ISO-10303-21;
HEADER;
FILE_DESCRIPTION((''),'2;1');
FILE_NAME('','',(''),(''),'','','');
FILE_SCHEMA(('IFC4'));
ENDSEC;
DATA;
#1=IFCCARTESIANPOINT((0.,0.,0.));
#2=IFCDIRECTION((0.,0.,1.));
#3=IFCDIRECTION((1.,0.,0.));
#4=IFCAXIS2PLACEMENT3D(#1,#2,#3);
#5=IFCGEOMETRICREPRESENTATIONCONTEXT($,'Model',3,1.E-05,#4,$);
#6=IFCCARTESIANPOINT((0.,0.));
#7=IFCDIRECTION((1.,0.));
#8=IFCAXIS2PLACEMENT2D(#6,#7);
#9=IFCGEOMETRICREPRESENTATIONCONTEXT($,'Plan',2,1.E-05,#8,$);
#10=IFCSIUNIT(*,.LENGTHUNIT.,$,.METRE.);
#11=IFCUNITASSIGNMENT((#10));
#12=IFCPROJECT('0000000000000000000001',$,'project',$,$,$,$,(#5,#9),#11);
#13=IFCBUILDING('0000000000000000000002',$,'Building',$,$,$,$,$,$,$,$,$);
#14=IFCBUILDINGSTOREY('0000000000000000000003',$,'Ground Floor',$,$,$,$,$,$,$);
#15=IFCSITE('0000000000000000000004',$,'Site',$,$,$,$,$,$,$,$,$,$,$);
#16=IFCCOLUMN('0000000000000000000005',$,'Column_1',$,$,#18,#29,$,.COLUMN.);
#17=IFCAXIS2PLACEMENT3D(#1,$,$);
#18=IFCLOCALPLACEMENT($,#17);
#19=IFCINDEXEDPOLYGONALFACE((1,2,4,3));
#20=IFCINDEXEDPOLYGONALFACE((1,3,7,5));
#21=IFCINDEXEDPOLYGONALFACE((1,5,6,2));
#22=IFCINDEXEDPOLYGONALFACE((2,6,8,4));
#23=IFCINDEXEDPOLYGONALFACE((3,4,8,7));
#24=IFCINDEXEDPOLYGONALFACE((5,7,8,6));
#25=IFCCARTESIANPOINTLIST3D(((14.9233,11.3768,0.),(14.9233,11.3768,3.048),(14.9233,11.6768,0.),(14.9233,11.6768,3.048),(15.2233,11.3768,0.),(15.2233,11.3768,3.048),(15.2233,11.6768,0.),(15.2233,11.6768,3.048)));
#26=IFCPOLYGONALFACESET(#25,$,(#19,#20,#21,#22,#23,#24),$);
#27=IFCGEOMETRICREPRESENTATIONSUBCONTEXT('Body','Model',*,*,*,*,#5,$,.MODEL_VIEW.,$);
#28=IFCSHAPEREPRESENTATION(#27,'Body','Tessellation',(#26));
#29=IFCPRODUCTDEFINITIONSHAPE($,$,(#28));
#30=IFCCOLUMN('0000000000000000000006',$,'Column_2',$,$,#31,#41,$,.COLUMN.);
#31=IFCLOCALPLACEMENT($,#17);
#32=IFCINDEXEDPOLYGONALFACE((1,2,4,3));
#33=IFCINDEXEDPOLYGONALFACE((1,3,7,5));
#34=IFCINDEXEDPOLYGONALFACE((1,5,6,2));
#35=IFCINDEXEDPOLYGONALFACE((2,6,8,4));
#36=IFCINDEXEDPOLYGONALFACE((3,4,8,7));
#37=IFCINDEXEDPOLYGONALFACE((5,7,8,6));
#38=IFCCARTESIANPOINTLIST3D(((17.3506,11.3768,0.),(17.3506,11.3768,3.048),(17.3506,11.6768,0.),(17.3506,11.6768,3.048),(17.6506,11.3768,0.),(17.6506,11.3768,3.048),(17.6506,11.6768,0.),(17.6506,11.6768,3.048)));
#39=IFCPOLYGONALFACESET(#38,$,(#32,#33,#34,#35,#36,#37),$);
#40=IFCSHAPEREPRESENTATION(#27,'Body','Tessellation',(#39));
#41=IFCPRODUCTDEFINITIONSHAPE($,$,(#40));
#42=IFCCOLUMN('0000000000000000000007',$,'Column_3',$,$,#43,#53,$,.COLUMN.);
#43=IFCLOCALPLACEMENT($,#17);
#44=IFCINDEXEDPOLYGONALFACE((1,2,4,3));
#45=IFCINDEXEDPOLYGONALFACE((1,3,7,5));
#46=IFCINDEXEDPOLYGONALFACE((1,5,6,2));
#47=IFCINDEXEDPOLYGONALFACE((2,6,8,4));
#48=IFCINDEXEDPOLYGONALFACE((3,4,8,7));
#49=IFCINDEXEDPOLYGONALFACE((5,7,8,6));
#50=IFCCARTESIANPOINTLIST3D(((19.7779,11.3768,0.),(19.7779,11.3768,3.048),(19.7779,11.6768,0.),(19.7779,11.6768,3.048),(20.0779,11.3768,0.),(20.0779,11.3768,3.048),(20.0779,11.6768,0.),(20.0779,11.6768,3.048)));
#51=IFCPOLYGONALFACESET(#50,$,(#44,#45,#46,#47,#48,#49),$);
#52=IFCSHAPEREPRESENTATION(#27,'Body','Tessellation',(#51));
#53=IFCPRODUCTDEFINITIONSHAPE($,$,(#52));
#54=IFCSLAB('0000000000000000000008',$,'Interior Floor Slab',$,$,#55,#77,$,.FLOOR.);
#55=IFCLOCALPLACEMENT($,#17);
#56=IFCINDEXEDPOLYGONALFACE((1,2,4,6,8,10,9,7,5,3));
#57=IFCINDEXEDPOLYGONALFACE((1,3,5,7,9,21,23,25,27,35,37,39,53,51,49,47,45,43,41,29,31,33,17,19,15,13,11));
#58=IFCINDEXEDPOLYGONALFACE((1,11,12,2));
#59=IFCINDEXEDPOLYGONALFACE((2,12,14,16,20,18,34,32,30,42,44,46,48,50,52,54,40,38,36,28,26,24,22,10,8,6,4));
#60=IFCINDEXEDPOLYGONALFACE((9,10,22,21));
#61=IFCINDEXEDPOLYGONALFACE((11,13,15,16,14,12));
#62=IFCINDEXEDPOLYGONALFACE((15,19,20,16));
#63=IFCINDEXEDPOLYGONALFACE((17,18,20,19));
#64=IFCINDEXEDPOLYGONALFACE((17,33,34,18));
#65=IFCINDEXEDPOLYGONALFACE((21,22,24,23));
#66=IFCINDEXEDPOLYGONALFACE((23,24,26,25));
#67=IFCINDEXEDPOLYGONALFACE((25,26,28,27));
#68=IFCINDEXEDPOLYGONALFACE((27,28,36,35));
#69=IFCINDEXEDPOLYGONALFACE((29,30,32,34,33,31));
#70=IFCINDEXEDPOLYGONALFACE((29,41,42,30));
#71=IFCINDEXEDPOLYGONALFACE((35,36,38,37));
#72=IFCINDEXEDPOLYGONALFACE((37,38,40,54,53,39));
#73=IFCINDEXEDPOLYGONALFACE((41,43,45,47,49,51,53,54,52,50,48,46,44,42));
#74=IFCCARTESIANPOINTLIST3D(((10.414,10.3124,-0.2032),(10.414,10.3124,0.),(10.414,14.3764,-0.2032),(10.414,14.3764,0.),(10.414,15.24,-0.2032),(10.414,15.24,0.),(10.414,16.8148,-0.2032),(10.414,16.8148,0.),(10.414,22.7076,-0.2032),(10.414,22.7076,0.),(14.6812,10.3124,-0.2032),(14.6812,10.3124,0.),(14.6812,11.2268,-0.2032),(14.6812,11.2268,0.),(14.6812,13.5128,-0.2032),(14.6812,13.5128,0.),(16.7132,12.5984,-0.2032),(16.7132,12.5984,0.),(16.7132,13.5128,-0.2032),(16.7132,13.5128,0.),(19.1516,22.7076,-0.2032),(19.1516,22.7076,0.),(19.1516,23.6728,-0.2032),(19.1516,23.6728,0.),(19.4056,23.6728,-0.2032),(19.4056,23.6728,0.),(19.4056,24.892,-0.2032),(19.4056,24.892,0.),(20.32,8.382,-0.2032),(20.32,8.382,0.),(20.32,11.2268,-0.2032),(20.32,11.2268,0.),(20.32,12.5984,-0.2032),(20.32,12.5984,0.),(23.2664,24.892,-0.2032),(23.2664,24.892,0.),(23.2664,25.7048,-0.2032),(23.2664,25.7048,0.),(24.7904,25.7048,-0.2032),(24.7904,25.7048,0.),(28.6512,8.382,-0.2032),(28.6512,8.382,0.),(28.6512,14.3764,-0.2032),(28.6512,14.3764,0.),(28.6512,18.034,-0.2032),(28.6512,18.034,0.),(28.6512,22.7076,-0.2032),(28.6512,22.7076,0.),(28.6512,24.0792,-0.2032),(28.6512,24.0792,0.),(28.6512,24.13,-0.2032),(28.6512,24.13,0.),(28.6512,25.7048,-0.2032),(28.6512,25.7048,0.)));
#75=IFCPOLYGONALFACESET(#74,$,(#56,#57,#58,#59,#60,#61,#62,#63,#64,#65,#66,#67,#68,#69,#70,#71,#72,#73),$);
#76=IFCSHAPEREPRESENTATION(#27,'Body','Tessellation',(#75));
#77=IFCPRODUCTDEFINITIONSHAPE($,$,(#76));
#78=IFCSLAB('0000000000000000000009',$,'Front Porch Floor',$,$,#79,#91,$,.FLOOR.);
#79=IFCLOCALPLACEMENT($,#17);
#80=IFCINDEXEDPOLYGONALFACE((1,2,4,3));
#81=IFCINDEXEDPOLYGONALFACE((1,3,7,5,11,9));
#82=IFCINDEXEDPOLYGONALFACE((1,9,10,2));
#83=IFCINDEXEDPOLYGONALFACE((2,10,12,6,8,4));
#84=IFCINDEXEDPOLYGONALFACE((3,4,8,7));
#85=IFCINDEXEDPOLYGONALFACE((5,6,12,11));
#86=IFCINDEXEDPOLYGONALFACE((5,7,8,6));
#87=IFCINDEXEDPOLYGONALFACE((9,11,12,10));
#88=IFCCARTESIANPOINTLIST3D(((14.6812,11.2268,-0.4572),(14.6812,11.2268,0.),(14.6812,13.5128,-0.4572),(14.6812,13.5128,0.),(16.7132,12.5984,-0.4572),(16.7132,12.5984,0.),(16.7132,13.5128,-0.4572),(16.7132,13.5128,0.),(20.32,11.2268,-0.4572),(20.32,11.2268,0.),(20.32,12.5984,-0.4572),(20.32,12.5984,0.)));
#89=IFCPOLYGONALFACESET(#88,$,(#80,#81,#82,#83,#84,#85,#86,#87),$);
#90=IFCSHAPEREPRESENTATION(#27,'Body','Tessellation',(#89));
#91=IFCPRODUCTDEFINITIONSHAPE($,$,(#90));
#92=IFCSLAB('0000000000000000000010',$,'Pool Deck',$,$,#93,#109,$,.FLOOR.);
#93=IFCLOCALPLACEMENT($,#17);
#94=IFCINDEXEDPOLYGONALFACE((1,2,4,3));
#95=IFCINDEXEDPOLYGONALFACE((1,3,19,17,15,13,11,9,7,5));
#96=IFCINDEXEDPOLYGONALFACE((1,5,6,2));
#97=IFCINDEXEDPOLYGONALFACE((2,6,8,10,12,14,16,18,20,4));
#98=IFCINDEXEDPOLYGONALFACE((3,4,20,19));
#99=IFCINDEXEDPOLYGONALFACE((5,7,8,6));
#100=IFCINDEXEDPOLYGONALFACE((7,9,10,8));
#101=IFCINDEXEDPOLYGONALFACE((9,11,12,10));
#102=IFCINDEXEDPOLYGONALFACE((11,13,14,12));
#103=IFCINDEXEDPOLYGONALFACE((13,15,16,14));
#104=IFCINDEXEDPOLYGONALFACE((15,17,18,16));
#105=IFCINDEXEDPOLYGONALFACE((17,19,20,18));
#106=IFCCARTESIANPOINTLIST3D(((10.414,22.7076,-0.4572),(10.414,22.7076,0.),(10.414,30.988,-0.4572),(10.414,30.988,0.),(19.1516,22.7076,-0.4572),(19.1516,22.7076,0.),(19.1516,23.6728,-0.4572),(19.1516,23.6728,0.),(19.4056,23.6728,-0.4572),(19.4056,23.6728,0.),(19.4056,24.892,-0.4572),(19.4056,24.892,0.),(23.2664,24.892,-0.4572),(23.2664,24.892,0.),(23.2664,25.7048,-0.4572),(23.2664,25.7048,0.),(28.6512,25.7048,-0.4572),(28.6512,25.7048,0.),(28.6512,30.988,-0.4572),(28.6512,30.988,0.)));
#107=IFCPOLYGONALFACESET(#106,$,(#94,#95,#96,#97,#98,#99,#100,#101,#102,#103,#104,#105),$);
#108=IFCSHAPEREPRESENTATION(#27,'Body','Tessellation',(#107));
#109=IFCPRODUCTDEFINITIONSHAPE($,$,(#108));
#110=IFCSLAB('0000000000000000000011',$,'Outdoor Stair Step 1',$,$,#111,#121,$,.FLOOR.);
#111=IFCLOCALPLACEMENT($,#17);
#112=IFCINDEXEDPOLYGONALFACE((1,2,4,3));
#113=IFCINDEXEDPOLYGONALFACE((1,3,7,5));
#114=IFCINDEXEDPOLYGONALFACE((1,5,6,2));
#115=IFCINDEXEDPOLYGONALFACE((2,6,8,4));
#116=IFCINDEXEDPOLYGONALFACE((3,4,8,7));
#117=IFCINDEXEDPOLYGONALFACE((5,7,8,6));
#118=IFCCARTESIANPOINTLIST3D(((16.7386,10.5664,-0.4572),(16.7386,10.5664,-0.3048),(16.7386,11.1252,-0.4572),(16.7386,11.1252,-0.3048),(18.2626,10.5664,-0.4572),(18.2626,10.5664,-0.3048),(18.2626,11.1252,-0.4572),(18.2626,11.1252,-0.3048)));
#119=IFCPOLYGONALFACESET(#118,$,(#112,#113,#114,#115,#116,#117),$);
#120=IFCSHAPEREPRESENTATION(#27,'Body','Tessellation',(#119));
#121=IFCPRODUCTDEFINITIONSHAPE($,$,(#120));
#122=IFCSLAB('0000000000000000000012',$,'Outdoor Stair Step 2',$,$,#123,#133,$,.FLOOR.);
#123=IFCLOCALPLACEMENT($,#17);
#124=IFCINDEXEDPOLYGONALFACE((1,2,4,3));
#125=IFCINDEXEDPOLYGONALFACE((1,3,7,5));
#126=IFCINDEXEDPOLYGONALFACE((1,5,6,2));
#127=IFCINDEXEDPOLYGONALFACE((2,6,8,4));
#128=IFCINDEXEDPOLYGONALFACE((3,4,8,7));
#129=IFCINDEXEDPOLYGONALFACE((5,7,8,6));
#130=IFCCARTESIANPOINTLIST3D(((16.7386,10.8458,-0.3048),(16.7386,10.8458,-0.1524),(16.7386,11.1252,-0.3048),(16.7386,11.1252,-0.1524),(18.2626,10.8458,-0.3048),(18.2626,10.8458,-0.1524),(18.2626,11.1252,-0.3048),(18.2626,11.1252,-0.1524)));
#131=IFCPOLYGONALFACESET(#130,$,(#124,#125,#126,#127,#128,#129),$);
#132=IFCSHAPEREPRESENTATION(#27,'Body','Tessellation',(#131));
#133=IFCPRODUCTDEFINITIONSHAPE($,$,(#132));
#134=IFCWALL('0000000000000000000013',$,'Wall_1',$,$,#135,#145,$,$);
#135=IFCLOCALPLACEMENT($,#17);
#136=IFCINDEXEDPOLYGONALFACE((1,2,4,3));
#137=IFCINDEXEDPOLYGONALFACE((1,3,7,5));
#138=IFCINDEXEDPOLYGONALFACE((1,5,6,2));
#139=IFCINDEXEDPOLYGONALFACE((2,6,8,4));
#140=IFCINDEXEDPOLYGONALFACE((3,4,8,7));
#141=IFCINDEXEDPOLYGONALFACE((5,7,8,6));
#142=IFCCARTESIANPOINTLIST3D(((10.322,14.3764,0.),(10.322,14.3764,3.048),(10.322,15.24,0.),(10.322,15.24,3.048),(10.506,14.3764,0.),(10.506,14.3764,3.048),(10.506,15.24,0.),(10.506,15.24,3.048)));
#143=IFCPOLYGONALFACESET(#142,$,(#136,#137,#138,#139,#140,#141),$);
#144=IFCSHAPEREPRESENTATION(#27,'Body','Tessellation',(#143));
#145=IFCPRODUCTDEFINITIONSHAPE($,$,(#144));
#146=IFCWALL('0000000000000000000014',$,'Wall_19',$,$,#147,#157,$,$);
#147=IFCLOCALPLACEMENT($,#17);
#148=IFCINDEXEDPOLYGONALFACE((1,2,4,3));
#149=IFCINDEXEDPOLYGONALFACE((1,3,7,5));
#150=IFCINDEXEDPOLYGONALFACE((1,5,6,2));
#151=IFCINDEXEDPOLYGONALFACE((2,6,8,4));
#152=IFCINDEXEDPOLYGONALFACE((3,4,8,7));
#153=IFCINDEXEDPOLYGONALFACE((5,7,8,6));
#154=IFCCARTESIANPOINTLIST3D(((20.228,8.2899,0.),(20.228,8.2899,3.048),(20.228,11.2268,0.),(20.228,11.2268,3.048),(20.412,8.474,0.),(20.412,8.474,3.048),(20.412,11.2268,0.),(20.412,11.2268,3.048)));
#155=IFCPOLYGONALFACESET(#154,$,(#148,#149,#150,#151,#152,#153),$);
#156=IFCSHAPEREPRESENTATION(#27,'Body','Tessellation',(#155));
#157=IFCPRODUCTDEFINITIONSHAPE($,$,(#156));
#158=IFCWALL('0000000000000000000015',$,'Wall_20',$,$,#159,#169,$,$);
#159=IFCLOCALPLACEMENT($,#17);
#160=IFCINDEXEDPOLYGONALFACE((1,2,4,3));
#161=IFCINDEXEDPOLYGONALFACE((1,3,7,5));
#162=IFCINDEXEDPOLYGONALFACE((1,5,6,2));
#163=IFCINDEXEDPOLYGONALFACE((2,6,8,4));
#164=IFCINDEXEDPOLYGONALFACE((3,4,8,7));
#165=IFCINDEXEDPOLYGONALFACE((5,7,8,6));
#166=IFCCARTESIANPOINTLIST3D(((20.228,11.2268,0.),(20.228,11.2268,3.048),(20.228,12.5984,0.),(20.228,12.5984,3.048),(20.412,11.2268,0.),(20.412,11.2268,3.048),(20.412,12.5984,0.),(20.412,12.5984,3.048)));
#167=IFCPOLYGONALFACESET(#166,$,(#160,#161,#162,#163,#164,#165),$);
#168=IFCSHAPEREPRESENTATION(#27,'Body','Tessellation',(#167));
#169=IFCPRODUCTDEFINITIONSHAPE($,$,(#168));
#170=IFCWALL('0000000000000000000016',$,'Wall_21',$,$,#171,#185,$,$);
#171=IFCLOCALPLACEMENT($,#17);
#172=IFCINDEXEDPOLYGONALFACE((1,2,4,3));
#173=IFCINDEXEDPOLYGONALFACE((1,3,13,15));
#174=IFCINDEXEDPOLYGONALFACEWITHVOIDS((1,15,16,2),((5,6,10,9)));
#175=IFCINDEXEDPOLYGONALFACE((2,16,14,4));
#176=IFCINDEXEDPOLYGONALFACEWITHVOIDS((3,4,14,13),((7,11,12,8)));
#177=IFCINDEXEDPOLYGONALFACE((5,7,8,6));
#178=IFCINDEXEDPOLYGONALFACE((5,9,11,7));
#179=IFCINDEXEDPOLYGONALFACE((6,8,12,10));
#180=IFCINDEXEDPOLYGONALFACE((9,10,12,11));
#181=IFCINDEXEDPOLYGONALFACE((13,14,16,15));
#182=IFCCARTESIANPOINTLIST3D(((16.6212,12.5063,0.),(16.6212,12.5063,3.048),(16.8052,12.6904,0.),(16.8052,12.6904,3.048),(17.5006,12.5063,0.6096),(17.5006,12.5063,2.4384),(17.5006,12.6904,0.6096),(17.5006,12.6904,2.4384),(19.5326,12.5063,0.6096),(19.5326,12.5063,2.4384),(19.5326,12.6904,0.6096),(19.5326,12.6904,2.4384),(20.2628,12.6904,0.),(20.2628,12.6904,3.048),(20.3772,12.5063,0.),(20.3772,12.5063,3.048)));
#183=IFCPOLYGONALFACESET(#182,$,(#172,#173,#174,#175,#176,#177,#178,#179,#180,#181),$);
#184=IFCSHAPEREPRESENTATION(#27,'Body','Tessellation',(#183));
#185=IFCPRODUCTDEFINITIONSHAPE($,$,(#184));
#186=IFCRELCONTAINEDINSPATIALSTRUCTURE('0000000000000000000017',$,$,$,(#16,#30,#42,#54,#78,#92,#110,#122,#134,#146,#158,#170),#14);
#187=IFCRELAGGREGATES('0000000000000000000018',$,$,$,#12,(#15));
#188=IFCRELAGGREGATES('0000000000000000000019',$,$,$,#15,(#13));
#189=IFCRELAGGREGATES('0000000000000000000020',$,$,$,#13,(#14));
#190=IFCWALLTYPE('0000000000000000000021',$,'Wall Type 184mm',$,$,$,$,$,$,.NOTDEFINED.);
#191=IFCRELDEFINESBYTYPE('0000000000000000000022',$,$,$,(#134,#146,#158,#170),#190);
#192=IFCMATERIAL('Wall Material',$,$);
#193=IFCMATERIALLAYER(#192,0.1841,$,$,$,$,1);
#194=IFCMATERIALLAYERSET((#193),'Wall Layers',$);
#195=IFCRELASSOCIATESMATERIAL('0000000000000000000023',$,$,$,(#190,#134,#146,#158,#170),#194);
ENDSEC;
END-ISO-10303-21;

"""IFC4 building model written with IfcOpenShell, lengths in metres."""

from ifc_helpers import new_model, si_unit, frame, origin_with_axes, origin_2d_with_axis, place, context, subcontext, project, spatial, polyline, line, indexed_curve, rectangle, outline, extrude, material, layer, layer_set, layer_usage, type_object, element, save


model = new_model("IFC4")

# Units and contexts
model_context = context("Model", 3, precision=1e-05, world=origin_with_axes())
plan_context = context("Plan", 2, precision=1e-05, world=origin_2d_with_axis())
body_context = subcontext(model_context, "Body", "Model", "MODEL_VIEW")
ifc_project = project(units=[si_unit("LENGTHUNIT", "METRE")], contexts=[model_context, plan_context])

# Site, building, storey
site = spatial("IfcSite", under=ifc_project, Name="Site")
building = spatial("IfcBuilding", under=site, Name="Building")
storey = spatial("IfcBuildingStorey", under=building, Name="Ground Floor")

# Columns
for number, where, z_axis, x_axis, name in (
    (1, (15.0733, 11.5268, 0.0), (0.0, 0.0, 1.0), (1.0, 0.0, 0.0), "Column_1"),
    (2, (17.5006, 11.5268, 0.0), (0.0, 0.0, 1.0), (1.0, 0.0, 0.0), "Column_2"),
    (3, (19.9279, 11.5268, 0.0), (0.0, 0.0, 1.0), (1.0, 0.0, 0.0), "Column_3"),
):
    element("IfcColumn", number, at=place(None, frame(where, z_axis=z_axis, x_axis=x_axis)), inside=storey, Name=name, PredefinedType="COLUMN", context=body_context, shape_type="SweptSolid", body=[
        extrude(rectangle(XDim=0.3, YDim=0.3), None, (0.0, 0.0, 1.0), 3.048),
    ])

# Slabs
slab_1_placement = place(None, frame((0.0, 0.0, -0.2032), z_axis=(0.0, 0.0, 1.0), x_axis=(1.0, 0.0, 0.0)))
element("IfcSlab", 4, at=slab_1_placement, inside=storey, Name="Interior Floor Slab", PredefinedType="FLOOR", context=body_context, shape_type="SweptSolid", body=[
    extrude(outline(polyline([(10.414, 15.24), (10.414, 14.3764), (10.414, 10.3124), (14.6812, 10.3124), (14.6812, 11.2268), (14.6812, 13.5128), (16.7132, 13.5128), (16.7132, 12.5984), (20.32, 12.5984), (20.32, 11.2268), (20.32, 8.382), (28.6512, 8.382), (28.6512, 14.3764), (28.6512, 18.034), (28.6512, 22.7076), (28.6512, 24.0792), (28.6512, 24.13), (28.6512, 25.7048), (24.7904, 25.7048), (23.2664, 25.7048), (23.2664, 24.892), (19.4056, 24.892), (19.4056, 23.6728), (19.1516, 23.6728), (19.1516, 22.7076), (10.414, 22.7076), (10.414, 16.8148), (10.414, 15.24)])), None, (0.0, 0.0, 1.0), 0.2032),
])
slab_2_placement = place(None, frame((0.0, 0.0, -0.4572), z_axis=(0.0, 0.0, 1.0), x_axis=(1.0, 0.0, 0.0)))
element("IfcSlab", 5, at=slab_2_placement, inside=storey, Name="Front Porch Floor", PredefinedType="FLOOR", context=body_context, shape_type="SweptSolid", body=[
    extrude(outline(polyline([(14.6812, 13.5128), (14.6812, 11.2268), (20.32, 11.2268), (20.32, 12.5984), (16.7132, 12.5984), (16.7132, 13.5128), (14.6812, 13.5128)])), None, (0.0, 0.0, 1.0), 0.4572),
])
slab_3_placement = place(None, frame((0.0, 0.0, -0.4572), z_axis=(0.0, 0.0, 1.0), x_axis=(1.0, 0.0, 0.0)))
element("IfcSlab", 6, at=slab_3_placement, inside=storey, Name="Pool Deck", PredefinedType="FLOOR", context=body_context, shape_type="SweptSolid", body=[
    extrude(outline(polyline([(10.414, 30.988), (10.414, 22.7076), (19.1516, 22.7076), (19.1516, 23.6728), (19.4056, 23.6728), (19.4056, 24.892), (23.2664, 24.892), (23.2664, 25.7048), (28.6512, 25.7048), (28.6512, 30.988), (10.414, 30.988)])), None, (0.0, 0.0, 1.0), 0.4572),
])
slab_4_placement = place(None, frame((17.5006, 10.8458, -0.4572), z_axis=(0.0, 0.0, 1.0), x_axis=(1.0, 0.0, 0.0)))
element("IfcSlab", 7, at=slab_4_placement, inside=storey, Name="Outdoor Stair Step 1", PredefinedType="FLOOR", context=body_context, shape_type="SweptSolid", body=[
    extrude(rectangle(XDim=1.524, YDim=0.5588), None, (0.0, 0.0, 1.0), 0.1524),
])
slab_5_placement = place(None, frame((17.5006, 10.9855, -0.3048), z_axis=(0.0, 0.0, 1.0), x_axis=(1.0, 0.0, 0.0)))
element("IfcSlab", 8, at=slab_5_placement, inside=storey, Name="Outdoor Stair Step 2", PredefinedType="FLOOR", context=body_context, shape_type="SweptSolid", body=[
    extrude(rectangle(XDim=1.524, YDim=0.2794), None, (0.0, 0.0, 1.0), 0.1524),
])

# Walls
ifc_material_1 = material(Name="Wall Material")
ifc_layer_1 = layer(ifc_material_1, 0.1841, Priority=1)
ifc_layer_set_1 = layer_set([ifc_layer_1], Name="Wall Layers")
ifc_layer_usage_1 = layer_usage(ifc_layer_set_1, "AXIS2", "POSITIVE", -0.0921)
wall_type_1 = type_object("IfcWallType", Name="Wall Type 184mm", PredefinedType="NOTDEFINED", material=ifc_layer_set_1)
wall_1_placement = place(None, frame((10.414, 14.3764, 0.0), z_axis=(0.0, 0.0, 1.0), x_axis=(0.0, 1.0, 0.0)))
element("IfcWall", 9, at=wall_1_placement, inside=storey, type_object=wall_type_1, material=ifc_layer_usage_1, Name="Wall_1", context=body_context, shape_type="SweptSolid", body=[
    extrude(outline(indexed_curve([(0.0, -0.0921), (0.0, 0.0921), (0.8636, 0.0921), (0.8636, -0.0921)], segments=[line(1, 2, 3, 4, 1)])), origin_with_axes(), (0.0, 0.0, 1.0), 3.048),
])
ifc_layer_usage_2 = layer_usage(ifc_layer_set_1, "AXIS2", "POSITIVE", -0.0921)
wall_2_placement = place(None, frame((20.32, 8.382, 0.0), z_axis=(0.0, 0.0, 1.0), x_axis=(0.0, 1.0, 0.0)))
element("IfcWall", 10, at=wall_2_placement, inside=storey, type_object=wall_type_1, material=ifc_layer_usage_2, Name="Wall_19", context=body_context, shape_type="SweptSolid", body=[
    extrude(outline(indexed_curve([(0.0921, -0.0921), (-0.0921, 0.0921), (2.8448, 0.0921), (2.8448, -0.0921)], segments=[line(1, 2, 3, 4, 1)])), origin_with_axes(), (0.0, 0.0, 1.0), 3.048),
])
ifc_layer_usage_3 = layer_usage(ifc_layer_set_1, "AXIS2", "POSITIVE", -0.0921)
wall_3_placement = place(None, frame((20.32, 11.2268, 0.0), z_axis=(0.0, 0.0, 1.0), x_axis=(0.0, 1.0, 0.0)))
element("IfcWall", 11, at=wall_3_placement, inside=storey, type_object=wall_type_1, material=ifc_layer_usage_3, Name="Wall_20", context=body_context, shape_type="SweptSolid", body=[
    extrude(outline(indexed_curve([(0.0, -0.0921), (0.0, 0.0921), (1.3716, 0.0921), (1.3716, -0.0921)], segments=[line(1, 2, 3, 4, 1)])), origin_with_axes(), (0.0, 0.0, 1.0), 3.048),
])

# Wall, opening
ifc_layer_usage_4 = layer_usage(ifc_layer_set_1, "AXIS2", "POSITIVE", -0.0921)
wall_4_placement = place(None, frame((20.32, 12.5984, 0.0), z_axis=(0.0, 0.0, 1.0), x_axis=(-1.0, 0.0, 0.0)))
wall_4 = element("IfcWall", 12, at=wall_4_placement, inside=storey, type_object=wall_type_1, material=ifc_layer_usage_4, Name="Wall_21", context=body_context, shape_type="SweptSolid", body=[
    extrude(outline(indexed_curve([(0.0572, -0.0921), (-0.0572, 0.0921), (3.6989, 0.0921), (3.5148, -0.0921)], segments=[line(1, 2, 3, 4, 1)])), origin_with_axes(), (0.0, 0.0, 1.0), 3.048),
])
opening_1_placement = place(wall_4_placement, frame((1.8034, 0.0, 0.6096), z_axis=(0.0, 0.0, 1.0), x_axis=(1.0, 0.0, 0.0)))
element("IfcOpeningElement", 13, at=opening_1_placement, cuts=wall_4, context=body_context, shape_type="SweptSolid", body=[
    extrude(rectangle(XDim=2.032, YDim=0.5524), None, (0.0, 0.0, 1.0), 1.8288),
])

save(model, "model.ifc")
